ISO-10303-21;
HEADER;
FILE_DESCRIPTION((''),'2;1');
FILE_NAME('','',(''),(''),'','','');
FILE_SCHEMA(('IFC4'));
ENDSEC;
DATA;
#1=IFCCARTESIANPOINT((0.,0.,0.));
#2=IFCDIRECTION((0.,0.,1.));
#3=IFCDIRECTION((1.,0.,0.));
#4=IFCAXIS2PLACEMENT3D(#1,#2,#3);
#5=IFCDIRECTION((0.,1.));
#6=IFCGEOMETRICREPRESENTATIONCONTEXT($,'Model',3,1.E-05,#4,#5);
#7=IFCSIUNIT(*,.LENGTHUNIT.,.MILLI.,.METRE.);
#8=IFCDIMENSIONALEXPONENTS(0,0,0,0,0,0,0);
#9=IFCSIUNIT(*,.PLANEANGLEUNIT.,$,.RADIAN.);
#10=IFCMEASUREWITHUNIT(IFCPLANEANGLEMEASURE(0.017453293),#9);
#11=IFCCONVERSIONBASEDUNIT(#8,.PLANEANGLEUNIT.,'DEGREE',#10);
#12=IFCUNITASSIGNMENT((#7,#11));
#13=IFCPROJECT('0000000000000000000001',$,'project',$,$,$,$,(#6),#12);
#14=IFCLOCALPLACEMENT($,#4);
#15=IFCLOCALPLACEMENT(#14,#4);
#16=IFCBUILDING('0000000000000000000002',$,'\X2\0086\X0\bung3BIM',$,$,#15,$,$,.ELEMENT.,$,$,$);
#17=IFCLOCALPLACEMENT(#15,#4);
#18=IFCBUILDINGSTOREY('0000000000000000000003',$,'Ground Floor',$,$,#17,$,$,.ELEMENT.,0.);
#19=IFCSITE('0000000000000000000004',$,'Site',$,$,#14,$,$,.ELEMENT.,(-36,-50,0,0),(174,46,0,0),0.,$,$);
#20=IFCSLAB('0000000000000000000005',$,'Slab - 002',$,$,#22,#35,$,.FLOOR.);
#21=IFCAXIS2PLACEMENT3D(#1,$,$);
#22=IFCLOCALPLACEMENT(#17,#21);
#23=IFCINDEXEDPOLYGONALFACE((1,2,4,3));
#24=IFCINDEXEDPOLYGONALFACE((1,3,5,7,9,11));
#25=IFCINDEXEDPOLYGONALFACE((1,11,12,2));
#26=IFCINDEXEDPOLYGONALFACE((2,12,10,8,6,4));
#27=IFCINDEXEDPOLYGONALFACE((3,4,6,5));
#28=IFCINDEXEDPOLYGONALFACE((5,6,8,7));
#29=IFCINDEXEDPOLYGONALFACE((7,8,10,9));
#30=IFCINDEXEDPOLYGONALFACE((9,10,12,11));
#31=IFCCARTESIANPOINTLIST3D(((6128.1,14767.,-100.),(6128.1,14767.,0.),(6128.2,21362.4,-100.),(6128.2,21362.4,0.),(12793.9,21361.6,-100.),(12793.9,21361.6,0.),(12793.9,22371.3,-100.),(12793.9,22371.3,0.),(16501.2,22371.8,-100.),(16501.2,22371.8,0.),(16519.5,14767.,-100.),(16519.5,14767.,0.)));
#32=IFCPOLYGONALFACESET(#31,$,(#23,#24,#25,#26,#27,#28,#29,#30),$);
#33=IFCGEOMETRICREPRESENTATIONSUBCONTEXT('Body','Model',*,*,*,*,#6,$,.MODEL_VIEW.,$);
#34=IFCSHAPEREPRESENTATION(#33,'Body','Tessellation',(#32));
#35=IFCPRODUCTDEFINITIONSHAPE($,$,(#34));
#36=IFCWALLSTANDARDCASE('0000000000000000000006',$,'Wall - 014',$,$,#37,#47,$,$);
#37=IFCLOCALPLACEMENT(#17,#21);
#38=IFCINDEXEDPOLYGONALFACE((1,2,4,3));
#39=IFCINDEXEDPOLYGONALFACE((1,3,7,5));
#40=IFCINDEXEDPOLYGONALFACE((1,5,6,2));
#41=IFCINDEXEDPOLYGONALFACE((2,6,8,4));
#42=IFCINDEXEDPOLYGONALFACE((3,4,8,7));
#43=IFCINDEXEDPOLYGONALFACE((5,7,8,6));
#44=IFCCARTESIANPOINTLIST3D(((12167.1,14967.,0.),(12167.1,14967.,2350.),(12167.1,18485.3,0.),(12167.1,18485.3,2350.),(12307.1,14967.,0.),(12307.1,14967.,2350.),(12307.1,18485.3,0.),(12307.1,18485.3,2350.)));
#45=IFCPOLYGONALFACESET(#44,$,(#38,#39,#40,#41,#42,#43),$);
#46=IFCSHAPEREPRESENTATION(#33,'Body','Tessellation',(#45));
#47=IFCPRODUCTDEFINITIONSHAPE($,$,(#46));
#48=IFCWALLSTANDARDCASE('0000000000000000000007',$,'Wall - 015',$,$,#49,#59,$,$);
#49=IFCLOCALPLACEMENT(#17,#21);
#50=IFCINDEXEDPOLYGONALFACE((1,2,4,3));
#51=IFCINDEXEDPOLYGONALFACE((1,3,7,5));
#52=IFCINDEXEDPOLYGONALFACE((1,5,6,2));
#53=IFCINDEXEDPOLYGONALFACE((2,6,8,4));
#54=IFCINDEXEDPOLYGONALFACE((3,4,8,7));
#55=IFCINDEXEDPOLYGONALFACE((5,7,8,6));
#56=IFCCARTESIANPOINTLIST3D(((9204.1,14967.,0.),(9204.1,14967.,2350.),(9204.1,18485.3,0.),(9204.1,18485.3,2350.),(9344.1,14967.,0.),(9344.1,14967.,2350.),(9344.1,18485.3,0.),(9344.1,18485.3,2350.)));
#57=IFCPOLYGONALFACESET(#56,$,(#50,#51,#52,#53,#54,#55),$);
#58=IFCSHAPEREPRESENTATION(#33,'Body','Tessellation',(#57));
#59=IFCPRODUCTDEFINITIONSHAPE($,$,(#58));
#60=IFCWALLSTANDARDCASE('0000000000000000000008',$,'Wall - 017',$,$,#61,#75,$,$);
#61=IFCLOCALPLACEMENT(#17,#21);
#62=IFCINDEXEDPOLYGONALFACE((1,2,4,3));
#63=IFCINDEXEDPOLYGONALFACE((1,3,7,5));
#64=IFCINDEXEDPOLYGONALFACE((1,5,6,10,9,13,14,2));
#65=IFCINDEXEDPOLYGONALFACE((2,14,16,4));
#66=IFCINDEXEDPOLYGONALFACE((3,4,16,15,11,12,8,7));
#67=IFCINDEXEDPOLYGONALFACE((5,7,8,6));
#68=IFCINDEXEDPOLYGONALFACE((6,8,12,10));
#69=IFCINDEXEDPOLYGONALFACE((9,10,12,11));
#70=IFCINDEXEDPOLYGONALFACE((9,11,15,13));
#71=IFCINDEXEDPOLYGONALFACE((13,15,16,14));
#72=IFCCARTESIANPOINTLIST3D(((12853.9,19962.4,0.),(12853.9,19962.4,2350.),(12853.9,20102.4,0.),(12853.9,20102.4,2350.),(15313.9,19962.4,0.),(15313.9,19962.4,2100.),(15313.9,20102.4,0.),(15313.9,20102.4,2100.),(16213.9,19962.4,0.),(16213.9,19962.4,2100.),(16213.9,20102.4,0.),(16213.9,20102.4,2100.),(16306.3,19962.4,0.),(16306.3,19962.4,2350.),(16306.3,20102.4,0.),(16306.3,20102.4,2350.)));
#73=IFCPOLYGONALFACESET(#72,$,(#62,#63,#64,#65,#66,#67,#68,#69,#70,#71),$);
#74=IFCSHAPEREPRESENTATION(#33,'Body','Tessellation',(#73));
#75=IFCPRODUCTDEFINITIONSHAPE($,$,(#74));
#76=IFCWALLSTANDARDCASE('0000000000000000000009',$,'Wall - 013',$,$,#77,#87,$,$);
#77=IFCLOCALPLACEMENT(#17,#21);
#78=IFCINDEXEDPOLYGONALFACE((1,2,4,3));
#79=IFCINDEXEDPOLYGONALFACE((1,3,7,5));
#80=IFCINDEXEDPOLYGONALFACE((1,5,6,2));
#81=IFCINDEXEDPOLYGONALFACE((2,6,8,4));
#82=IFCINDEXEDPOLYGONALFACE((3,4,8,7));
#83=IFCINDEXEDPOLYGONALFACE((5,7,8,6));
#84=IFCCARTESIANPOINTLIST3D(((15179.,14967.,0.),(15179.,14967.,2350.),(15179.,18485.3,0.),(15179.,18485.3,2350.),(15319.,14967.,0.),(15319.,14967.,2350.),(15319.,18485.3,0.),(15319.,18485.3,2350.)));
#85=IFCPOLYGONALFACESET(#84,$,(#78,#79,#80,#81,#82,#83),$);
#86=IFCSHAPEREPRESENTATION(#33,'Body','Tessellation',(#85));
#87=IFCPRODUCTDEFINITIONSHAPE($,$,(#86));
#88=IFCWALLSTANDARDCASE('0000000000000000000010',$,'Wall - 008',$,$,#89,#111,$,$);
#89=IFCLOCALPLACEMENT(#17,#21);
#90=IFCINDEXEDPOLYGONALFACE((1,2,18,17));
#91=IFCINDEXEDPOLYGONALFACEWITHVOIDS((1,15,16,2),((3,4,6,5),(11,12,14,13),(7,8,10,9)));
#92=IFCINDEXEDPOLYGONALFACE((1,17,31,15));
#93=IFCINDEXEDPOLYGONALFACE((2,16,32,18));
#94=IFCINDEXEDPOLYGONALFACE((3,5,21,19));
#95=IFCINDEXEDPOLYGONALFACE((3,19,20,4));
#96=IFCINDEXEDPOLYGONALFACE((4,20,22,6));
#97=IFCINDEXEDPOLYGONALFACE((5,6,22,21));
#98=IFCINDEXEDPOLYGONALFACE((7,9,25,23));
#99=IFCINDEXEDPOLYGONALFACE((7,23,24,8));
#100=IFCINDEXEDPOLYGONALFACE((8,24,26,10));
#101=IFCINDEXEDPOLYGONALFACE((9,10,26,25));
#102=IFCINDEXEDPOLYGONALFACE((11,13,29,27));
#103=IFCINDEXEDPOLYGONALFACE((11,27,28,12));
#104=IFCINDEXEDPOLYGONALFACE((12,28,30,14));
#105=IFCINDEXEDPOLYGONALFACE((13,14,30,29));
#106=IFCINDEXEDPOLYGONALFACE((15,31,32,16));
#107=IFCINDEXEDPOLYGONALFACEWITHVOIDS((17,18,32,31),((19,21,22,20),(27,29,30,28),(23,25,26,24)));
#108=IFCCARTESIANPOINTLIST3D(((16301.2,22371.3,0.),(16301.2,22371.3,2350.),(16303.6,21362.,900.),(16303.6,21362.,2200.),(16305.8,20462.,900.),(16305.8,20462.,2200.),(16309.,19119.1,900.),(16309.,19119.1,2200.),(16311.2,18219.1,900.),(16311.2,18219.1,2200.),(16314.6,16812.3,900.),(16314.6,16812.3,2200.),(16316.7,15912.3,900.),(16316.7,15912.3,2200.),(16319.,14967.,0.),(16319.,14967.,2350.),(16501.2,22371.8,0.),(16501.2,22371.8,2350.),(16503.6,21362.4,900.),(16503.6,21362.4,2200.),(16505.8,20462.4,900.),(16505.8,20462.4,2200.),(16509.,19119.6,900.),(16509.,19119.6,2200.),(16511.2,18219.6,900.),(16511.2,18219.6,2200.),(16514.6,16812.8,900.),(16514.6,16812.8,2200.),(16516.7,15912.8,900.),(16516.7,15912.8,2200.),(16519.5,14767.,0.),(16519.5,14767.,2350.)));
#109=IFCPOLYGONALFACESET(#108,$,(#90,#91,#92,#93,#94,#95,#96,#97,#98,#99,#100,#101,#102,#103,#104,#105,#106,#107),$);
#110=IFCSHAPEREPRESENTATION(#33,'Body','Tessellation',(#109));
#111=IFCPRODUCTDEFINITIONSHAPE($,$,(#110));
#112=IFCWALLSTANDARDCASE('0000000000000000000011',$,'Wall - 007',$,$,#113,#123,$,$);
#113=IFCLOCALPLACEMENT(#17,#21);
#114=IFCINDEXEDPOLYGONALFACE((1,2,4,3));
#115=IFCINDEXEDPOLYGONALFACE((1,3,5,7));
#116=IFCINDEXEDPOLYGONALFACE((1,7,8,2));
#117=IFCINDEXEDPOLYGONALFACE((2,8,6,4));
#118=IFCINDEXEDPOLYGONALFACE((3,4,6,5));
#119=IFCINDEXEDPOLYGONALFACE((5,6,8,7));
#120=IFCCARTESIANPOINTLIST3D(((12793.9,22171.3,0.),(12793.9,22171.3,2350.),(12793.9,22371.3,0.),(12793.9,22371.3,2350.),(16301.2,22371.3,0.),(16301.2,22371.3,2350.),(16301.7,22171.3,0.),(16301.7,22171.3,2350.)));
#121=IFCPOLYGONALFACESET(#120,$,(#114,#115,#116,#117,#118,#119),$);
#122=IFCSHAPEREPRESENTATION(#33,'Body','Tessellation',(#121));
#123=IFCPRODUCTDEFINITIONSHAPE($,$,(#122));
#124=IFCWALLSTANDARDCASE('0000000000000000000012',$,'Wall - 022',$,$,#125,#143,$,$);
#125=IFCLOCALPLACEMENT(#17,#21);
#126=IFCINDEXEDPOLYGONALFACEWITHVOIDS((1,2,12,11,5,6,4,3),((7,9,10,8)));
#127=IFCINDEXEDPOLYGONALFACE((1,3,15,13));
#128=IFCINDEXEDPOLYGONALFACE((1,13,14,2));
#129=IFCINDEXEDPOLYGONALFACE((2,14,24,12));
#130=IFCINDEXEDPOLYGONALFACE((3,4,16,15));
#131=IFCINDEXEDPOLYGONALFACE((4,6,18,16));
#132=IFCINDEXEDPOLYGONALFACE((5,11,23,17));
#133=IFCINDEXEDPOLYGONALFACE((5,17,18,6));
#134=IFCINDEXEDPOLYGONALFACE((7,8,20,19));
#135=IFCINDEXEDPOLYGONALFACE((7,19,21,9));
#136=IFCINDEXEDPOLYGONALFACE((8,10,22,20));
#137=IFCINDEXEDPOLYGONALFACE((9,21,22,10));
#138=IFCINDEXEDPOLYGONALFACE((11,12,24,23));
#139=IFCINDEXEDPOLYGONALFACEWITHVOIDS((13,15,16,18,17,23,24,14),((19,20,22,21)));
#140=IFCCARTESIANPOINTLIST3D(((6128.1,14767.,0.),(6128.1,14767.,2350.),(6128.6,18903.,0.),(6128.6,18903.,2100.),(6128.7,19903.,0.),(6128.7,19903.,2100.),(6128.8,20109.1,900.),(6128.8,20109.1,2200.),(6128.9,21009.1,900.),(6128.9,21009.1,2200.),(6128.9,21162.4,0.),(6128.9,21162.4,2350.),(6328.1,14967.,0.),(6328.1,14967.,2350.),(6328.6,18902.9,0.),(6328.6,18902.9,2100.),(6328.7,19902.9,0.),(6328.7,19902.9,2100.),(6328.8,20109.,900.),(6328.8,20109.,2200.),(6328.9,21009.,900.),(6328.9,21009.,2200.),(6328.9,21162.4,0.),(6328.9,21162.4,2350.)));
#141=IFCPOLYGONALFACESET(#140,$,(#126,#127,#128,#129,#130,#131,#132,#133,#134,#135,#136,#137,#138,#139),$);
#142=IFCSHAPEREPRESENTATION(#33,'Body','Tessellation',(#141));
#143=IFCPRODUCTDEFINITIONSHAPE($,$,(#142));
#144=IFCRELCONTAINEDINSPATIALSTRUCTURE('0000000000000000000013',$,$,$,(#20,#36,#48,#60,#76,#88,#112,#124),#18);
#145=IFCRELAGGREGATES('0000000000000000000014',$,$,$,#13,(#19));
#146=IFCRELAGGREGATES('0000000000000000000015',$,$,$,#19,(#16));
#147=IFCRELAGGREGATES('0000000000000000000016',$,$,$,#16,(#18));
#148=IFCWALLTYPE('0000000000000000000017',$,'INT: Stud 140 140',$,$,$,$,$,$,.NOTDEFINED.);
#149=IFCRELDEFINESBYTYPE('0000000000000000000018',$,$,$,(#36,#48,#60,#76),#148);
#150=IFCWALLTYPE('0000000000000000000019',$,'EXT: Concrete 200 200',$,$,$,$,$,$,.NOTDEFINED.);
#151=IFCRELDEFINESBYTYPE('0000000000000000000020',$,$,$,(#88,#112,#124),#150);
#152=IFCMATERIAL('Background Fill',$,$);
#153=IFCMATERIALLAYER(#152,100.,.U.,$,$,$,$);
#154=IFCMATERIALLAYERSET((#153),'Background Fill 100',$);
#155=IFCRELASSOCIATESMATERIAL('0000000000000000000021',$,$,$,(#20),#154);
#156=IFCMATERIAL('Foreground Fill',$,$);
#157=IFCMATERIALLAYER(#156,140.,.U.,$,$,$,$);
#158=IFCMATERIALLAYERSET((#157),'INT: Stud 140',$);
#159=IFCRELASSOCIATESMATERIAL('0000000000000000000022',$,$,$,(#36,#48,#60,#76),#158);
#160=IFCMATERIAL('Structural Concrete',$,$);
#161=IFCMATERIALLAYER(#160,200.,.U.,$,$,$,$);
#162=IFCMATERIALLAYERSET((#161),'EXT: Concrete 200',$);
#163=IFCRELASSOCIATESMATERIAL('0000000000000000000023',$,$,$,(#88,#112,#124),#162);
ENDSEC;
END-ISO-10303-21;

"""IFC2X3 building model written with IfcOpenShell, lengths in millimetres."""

from ifc_helpers import new_model, entity, si_unit, converted_unit, direction, frame, origin_with_axes, origin_2d_with_axis, place, context, subcontext, project, spatial, polyline, rectangle, outline, extrude, material, layer, layer_set, layer_usage, type_object, element, save


model = new_model("IFC2X3")

# Units and contexts
model_context = context("Model", 3, precision=1e-05, world=origin_with_axes(), true_north=direction((0.0, 1.0)))
body_context = subcontext(model_context, "Body", "Model", "MODEL_VIEW")
ifc_project = project(units=[si_unit("LENGTHUNIT", "METRE", prefix="MILLI"), converted_unit("PLANEANGLEUNIT", "DEGREE", entity("IfcPlaneAngleMeasure", 0.017453293), si_unit("PLANEANGLEUNIT", "RADIAN"), dimensions=[0, 0, 0, 0, 0, 0, 0])], contexts=[model_context])

# Site, building, storey
site_placement = place(None, origin_with_axes())
site = spatial("IfcSite", under=ifc_project, at=site_placement, Name="Site", CompositionType="ELEMENT", RefLatitude=(-36, -50, 0, 0), RefLongitude=(174, 46, 0, 0), RefElevation=0.0)
building_placement = place(site_placement, origin_with_axes())
building = spatial("IfcBuilding", under=site, at=building_placement, Name="\u0086bung3BIM", CompositionType="ELEMENT")
storey_placement = place(building_placement, origin_with_axes())
storey = spatial("IfcBuildingStorey", under=building, at=storey_placement, Name="Ground Floor", CompositionType="ELEMENT", Elevation=0.0)

# Slab
ifc_material_1 = material(Name="Background Fill")
ifc_layer_1 = layer(ifc_material_1, 100.0, ventilated="UNKNOWN")
ifc_layer_set_1 = layer_set([ifc_layer_1], Name="Background Fill 100")
ifc_layer_usage_1 = layer_usage(ifc_layer_set_1, "AXIS3", "NEGATIVE", 100.0)
slab_placement = place(storey_placement, frame((16501.2, 22371.8, -100.0), z_axis=(0.0, 0.0, 1.0), x_axis=(1.0, 0.0, 0.0)))
element("IfcSlab", 1, at=slab_placement, inside=storey, material=ifc_layer_usage_1, Name="Slab - 002", PredefinedType="FLOOR", context=body_context, shape_type="SweptSolid", body=[
    extrude(outline(polyline([(0.0, 0.0), (-3707.3, -0.5), (-3707.3, -1010.1), (-10373.0, -1009.3), (-10373.1, -7604.7), (18.3, -7604.7), (0.0, 0.0)])), origin_with_axes(), (0.0, 0.0, 1.0), 100.0),
])

# Shared definitions
ifc_material_2 = material(Name="Foreground Fill")
ifc_layer_2 = layer(ifc_material_2, 140.0, ventilated="UNKNOWN")
ifc_layer_set_2 = layer_set([ifc_layer_2], Name="INT: Stud 140")
wall_type_1 = type_object("IfcWallType", Name="INT: Stud 140 140", PredefinedType="NOTDEFINED")

# Walls
ifc_layer_usage_2 = layer_usage(ifc_layer_set_2, "AXIS2", "POSITIVE", 0.0)
wall_1_placement = place(storey_placement, frame((12167.1, 18485.3, 0.0), z_axis=(0.0, 0.0, 1.0), x_axis=(0.0, -1.0, 0.0)))
element("IfcWallStandardCase", 2, at=wall_1_placement, inside=storey, type_object=wall_type_1, material=ifc_layer_usage_2, Name="Wall - 014", context=body_context, shape_type="SweptSolid", body=[
    extrude(outline(polyline([(0.0, 0.0), (3518.3, 0.0), (3518.3, 140.0), (0.0, 140.0), (0.0, 0.0)])), origin_with_axes(), (0.0, 0.0, 1.0), 2350.0),
])
ifc_layer_usage_3 = layer_usage(ifc_layer_set_2, "AXIS2", "POSITIVE", 0.0)
wall_2_placement = place(storey_placement, frame((9204.1, 18485.3, 0.0), z_axis=(0.0, 0.0, 1.0), x_axis=(0.0, -1.0, 0.0)))
element("IfcWallStandardCase", 3, at=wall_2_placement, inside=storey, type_object=wall_type_1, material=ifc_layer_usage_3, Name="Wall - 015", context=body_context, shape_type="SweptSolid", body=[
    extrude(outline(polyline([(0.0, 0.0), (3518.3, 0.0), (3518.3, 140.0), (0.0, 140.0), (0.0, 0.0)])), origin_with_axes(), (0.0, 0.0, 1.0), 2350.0),
])

# Wall, opening
ifc_layer_usage_4 = layer_usage(ifc_layer_set_2, "AXIS2", "POSITIVE", 0.0)
wall_3_placement = place(storey_placement, frame((12853.9, 19962.4, 0.0), z_axis=(0.0, 0.0, 1.0), x_axis=(1.0, 0.0, 0.0)))
wall_3 = element("IfcWallStandardCase", 4, at=wall_3_placement, inside=storey, type_object=wall_type_1, material=ifc_layer_usage_4, Name="Wall - 017", context=body_context, shape_type="SweptSolid", body=[
    extrude(outline(polyline([(0.0, 0.0), (3452.4, 0.0), (3452.4, 140.0), (0.0, 140.0), (0.0, 0.0)])), origin_with_axes(), (0.0, 0.0, 1.0), 2350.0),
])
opening_1_placement = place(wall_3_placement, frame((2910.0, 0.0, 0.0), z_axis=(0.0, 0.0, 1.0), x_axis=(1.0, 0.0, 0.0)))
element("IfcOpeningElement", 5, at=opening_1_placement, cuts=wall_3, context=body_context, shape_type="SweptSolid", body=[
    extrude(rectangle(XDim=900.0, YDim=2100.0, at=origin_2d_with_axis()), frame((0.0, 280.0, 1050.0), z_axis=(0.0, 1.0, 0.0), x_axis=(1.0, 0.0, 0.0)), (0.0, 0.0, -1.0), 420.0),
])

# Wall
ifc_layer_usage_5 = layer_usage(ifc_layer_set_2, "AXIS2", "POSITIVE", 0.0)
wall_4_placement = place(storey_placement, frame((15179.0, 18485.3, 0.0), z_axis=(0.0, 0.0, 1.0), x_axis=(0.0, -1.0, 0.0)))
element("IfcWallStandardCase", 6, at=wall_4_placement, inside=storey, type_object=wall_type_1, material=ifc_layer_usage_5, Name="Wall - 013", context=body_context, shape_type="SweptSolid", body=[
    extrude(outline(polyline([(0.0, 0.0), (3518.3, 0.0), (3518.3, 140.0), (0.0, 140.0), (0.0, 0.0)])), origin_with_axes(), (0.0, 0.0, 1.0), 2350.0),
])

# Wall, openings
ifc_material_3 = material(Name="Structural Concrete")
ifc_layer_3 = layer(ifc_material_3, 200.0, ventilated="UNKNOWN")
ifc_layer_set_3 = layer_set([ifc_layer_3], Name="EXT: Concrete 200")
ifc_layer_usage_6 = layer_usage(ifc_layer_set_3, "AXIS2", "POSITIVE", 0.0)
wall_type_2 = type_object("IfcWallType", Name="EXT: Concrete 200 200", PredefinedType="NOTDEFINED")
wall_5_placement = place(storey_placement, frame((16301.2, 22371.3, 0.0), z_axis=(0.0, 0.0, 1.0), x_axis=(0.002401, -0.999997, 0.0)))
wall_5 = element("IfcWallStandardCase", 7, at=wall_5_placement, inside=storey, type_object=wall_type_2, material=ifc_layer_usage_6, Name="Wall - 008", context=body_context, shape_type="SweptSolid", body=[
    extrude(outline(polyline([(0.0, 0.0), (7404.3, 0.0), (7604.8, 200.0), (0.0, 200.0), (0.0, 0.0)])), origin_with_axes(), (0.0, 0.0, 1.0), 2350.0),
])
opening_2_placement = place(wall_5_placement, frame((3702.1, 0.0, 900.0), z_axis=(0.0, 0.0, 1.0), x_axis=(1.0, 0.0, 0.0)))
element("IfcOpeningElement", 8, at=opening_2_placement, cuts=wall_5, context=body_context, shape_type="SweptSolid", body=[
    extrude(rectangle(XDim=900.0, YDim=1300.0, at=origin_2d_with_axis()), frame((0.0, -200.0, 650.0), z_axis=(0.0, 1.0, 0.0), x_axis=(1.0, 0.0, 0.0)), (0.0, 0.0, 1.0), 600.0),
])
opening_3_placement = place(wall_5_placement, frame((6009.0, 0.0, 900.0), z_axis=(0.0, 0.0, 1.0), x_axis=(1.0, 0.0, 0.0)))
element("IfcOpeningElement", 9, at=opening_3_placement, cuts=wall_5, context=body_context, shape_type="SweptSolid", body=[
    extrude(rectangle(XDim=900.0, YDim=1300.0, at=origin_2d_with_axis()), frame((0.0, -200.0, 650.0), z_axis=(0.0, -1.0, 0.0), x_axis=(-1.0, 0.0, 0.0)), (0.0, 0.0, -1.0), 600.0),
])
opening_4_placement = place(wall_5_placement, frame((1459.3, 0.0, 900.0), z_axis=(0.0, 0.0, 1.0), x_axis=(1.0, 0.0, 0.0)))
element("IfcOpeningElement", 10, at=opening_4_placement, cuts=wall_5, context=body_context, shape_type="SweptSolid", body=[
    extrude(rectangle(XDim=900.0, YDim=1300.0, at=origin_2d_with_axis()), frame((0.0, -200.0, 650.0), z_axis=(0.0, -1.0, 0.0), x_axis=(-1.0, 0.0, 0.0)), (0.0, 0.0, -1.0), 600.0),
])

# Wall
ifc_layer_usage_7 = layer_usage(ifc_layer_set_3, "AXIS2", "POSITIVE", 0.0)
wall_6_placement = place(storey_placement, frame((12793.9, 22171.3, 0.0), z_axis=(0.0, 0.0, 1.0), x_axis=(1.0, 0.0, 0.0)))
element("IfcWallStandardCase", 11, at=wall_6_placement, inside=storey, type_object=wall_type_2, material=ifc_layer_usage_7, Name="Wall - 007", context=body_context, shape_type="SweptSolid", body=[
    extrude(outline(polyline([(0.0, 0.0), (3507.8, 0.0), (3507.3, 200.0), (0.0, 200.0), (0.0, 0.0)])), origin_with_axes(), (0.0, 0.0, 1.0), 2350.0),
])

# Wall, openings
ifc_layer_usage_8 = layer_usage(ifc_layer_set_3, "AXIS2", "POSITIVE", 0.0)
wall_7_placement = place(storey_placement, frame((6328.1, 14967.0, 0.0), z_axis=(0.0, 0.0, 1.0), x_axis=(0.000123, 1.0, 0.0)))
wall_7 = element("IfcWallStandardCase", 12, at=wall_7_placement, inside=storey, type_object=wall_type_2, material=ifc_layer_usage_8, Name="Wall - 022", context=body_context, shape_type="SweptSolid", body=[
    extrude(outline(polyline([(0.0, 0.0), (6195.4, 0.0), (6195.4, 200.0), (-200.0, 200.0), (0.0, 0.0)])), origin_with_axes(), (0.0, 0.0, 1.0), 2350.0),
])
opening_5_placement = place(wall_7_placement, frame((4435.9, 0.0, 0.0), z_axis=(0.0, 0.0, 1.0), x_axis=(1.0, 0.0, 0.0)))
element("IfcOpeningElement", 13, at=opening_5_placement, cuts=wall_7, context=body_context, shape_type="SweptSolid", body=[
    extrude(rectangle(XDim=1000.0, YDim=2100.0, at=origin_2d_with_axis()), frame((0.0, 400.0, 1050.0), z_axis=(0.0, -1.0, 0.0), x_axis=(-1.0, 0.0, 0.0)), (0.0, 0.0, 1.0), 600.0),
])
opening_6_placement = place(wall_7_placement, frame((5592.0, 0.0, 900.0), z_axis=(0.0, 0.0, 1.0), x_axis=(1.0, 0.0, 0.0)))
element("IfcOpeningElement", 14, at=opening_6_placement, cuts=wall_7, context=body_context, shape_type="SweptSolid", body=[
    extrude(rectangle(XDim=900.0, YDim=1300.0, at=origin_2d_with_axis()), frame((0.0, -200.0, 650.0), z_axis=(0.0, 1.0, 0.0), x_axis=(1.0, 0.0, 0.0)), (0.0, 0.0, 1.0), 600.0),
])

save(model, "model.ifc")
